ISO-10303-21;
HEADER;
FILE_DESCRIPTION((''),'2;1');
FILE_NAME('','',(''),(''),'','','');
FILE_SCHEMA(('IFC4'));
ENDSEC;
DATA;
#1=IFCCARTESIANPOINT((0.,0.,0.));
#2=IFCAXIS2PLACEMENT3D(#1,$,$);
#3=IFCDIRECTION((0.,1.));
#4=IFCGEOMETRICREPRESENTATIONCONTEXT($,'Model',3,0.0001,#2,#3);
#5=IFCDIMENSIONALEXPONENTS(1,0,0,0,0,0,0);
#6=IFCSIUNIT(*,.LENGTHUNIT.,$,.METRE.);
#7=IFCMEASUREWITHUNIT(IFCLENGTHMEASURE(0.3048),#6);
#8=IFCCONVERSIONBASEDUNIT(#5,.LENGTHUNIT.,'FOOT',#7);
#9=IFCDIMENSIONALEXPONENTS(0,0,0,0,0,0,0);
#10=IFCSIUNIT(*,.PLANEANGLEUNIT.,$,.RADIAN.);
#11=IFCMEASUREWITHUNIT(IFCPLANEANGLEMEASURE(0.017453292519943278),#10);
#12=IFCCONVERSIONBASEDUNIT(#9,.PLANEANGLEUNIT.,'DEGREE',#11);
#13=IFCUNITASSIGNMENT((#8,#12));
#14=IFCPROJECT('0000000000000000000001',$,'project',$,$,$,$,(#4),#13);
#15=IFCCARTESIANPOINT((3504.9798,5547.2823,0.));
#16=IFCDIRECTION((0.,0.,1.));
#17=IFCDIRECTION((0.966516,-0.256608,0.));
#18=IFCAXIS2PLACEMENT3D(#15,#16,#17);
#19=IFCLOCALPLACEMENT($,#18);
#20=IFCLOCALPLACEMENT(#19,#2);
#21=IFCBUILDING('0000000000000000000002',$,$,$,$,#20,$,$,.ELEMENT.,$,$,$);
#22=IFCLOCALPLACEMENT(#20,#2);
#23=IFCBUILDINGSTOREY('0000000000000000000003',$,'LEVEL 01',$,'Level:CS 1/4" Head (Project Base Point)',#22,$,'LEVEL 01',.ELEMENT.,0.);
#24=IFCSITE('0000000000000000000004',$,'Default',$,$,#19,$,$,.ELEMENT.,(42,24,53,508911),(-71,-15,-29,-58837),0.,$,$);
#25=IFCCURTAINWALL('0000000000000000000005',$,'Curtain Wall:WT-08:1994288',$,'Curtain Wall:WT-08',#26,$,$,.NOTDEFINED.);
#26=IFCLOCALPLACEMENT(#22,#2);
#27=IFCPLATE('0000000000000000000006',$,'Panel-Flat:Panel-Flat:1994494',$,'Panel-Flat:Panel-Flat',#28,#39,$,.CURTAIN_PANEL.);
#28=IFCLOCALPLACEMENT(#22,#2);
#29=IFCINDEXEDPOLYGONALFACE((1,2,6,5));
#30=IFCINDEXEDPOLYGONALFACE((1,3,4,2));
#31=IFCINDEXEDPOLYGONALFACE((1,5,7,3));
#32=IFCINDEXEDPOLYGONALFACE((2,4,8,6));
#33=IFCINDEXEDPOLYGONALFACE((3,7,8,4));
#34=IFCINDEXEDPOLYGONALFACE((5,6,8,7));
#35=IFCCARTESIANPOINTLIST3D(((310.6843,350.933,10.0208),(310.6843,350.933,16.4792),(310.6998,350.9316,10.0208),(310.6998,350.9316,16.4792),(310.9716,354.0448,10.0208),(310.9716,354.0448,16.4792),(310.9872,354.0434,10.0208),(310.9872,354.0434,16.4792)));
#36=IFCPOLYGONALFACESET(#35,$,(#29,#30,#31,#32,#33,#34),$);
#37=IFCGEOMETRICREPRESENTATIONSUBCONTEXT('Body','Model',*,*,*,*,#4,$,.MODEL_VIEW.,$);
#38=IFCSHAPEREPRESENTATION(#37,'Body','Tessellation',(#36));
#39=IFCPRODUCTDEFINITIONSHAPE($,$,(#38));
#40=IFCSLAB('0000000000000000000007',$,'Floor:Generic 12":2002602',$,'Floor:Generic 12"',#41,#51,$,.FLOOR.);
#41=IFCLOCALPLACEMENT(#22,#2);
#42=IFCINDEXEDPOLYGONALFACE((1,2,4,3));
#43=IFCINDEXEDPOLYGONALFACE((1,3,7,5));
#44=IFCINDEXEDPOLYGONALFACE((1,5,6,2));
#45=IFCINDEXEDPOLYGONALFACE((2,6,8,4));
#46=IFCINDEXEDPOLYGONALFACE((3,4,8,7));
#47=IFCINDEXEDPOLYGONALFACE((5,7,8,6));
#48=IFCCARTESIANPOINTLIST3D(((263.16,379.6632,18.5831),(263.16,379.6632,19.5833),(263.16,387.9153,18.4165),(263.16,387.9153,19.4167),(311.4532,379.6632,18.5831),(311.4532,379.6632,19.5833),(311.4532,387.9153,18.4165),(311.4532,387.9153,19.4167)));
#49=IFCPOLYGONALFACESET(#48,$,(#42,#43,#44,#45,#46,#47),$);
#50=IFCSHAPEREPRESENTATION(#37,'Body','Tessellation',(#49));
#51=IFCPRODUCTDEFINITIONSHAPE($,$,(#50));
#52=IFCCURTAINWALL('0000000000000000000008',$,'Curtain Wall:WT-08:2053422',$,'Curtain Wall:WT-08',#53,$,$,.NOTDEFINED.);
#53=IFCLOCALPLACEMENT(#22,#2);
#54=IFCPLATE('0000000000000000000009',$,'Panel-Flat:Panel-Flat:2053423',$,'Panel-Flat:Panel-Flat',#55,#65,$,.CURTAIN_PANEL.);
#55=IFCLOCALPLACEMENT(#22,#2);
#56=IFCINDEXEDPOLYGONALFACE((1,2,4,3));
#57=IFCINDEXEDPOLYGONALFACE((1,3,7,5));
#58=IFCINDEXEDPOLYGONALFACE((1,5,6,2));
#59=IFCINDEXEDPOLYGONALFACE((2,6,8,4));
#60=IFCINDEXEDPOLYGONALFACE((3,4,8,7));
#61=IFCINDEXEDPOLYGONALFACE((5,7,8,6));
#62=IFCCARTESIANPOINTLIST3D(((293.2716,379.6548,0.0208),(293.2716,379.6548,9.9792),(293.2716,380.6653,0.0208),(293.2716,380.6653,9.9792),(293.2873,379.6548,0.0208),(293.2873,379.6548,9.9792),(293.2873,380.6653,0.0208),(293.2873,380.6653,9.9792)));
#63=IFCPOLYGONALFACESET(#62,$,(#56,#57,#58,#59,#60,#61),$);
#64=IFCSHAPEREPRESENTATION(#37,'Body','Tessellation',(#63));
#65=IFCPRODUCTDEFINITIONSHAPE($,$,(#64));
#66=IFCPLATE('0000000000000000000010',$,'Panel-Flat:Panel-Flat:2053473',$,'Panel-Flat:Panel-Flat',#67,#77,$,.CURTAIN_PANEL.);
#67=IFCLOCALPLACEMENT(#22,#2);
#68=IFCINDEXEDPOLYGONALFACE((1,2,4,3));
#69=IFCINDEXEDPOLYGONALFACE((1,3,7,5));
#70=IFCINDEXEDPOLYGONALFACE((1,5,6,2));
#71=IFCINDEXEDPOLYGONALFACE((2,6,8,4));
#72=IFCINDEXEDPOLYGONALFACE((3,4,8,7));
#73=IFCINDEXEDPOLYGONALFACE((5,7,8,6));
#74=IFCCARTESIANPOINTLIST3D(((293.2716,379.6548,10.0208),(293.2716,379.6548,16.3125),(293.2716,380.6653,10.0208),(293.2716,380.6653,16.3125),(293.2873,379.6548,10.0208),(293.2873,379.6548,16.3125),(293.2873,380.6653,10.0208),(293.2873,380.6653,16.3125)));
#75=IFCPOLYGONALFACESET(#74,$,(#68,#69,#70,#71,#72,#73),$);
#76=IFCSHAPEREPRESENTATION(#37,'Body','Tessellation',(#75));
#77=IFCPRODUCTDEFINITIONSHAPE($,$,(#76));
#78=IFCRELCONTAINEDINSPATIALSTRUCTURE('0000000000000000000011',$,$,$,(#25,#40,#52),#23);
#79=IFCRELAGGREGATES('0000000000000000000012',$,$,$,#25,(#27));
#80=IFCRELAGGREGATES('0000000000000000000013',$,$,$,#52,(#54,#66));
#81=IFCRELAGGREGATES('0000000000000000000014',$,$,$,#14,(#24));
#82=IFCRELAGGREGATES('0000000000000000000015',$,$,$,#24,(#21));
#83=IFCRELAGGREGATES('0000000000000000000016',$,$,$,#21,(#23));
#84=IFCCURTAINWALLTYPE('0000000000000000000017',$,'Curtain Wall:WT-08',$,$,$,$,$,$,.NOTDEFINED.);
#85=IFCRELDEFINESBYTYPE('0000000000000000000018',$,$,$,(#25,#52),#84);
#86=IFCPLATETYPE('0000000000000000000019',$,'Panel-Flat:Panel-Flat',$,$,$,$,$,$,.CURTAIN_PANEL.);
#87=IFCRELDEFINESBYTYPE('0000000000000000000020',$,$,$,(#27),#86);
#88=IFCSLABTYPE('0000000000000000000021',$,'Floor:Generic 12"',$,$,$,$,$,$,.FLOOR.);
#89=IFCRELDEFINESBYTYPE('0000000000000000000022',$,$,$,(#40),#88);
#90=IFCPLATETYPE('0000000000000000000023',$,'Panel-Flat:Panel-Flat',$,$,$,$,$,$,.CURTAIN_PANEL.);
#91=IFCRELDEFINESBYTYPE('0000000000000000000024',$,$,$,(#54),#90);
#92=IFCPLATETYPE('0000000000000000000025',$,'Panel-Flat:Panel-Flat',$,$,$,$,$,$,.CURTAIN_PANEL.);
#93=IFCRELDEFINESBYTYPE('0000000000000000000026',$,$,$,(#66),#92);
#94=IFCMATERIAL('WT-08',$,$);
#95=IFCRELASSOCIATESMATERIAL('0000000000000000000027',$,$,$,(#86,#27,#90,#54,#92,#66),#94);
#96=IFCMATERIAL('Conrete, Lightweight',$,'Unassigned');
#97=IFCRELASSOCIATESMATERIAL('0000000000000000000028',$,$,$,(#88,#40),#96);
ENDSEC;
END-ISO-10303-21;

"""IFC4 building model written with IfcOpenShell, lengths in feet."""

from ifc_helpers import new_model, entity, si_unit, converted_unit, direction, frame, frame_2d, origin, place, context, subcontext, project, spatial, indexed_curve, rectangle, outline, extrude, source, transform, mapped, material, type_object, type_shapes, element, aggregate, save


model = new_model("IFC4")

# Units and contexts
model_context = context("Model", 3, precision=0.0001, world=origin(), true_north=direction((0.0, 1.0)))
body_context = subcontext(model_context, "Body", "Model", "MODEL_VIEW")
ifc_project = project(units=[converted_unit("LENGTHUNIT", "FOOT", entity("IfcLengthMeasure", 0.3048), si_unit("LENGTHUNIT", "METRE"), dimensions=[1, 0, 0, 0, 0, 0, 0]), converted_unit("PLANEANGLEUNIT", "DEGREE", entity("IfcPlaneAngleMeasure", 0.017453292519943278), si_unit("PLANEANGLEUNIT", "RADIAN"), dimensions=[0, 0, 0, 0, 0, 0, 0])], contexts=[model_context])

# Site, building, storey
site_placement = place(None, frame((3504.9798, 5547.2823, 0.0), z_axis=(0.0, 0.0, 1.0), x_axis=(0.966516, -0.256608, 0.0)))
site = spatial("IfcSite", under=ifc_project, at=site_placement, Name="Default", CompositionType="ELEMENT", RefLatitude=(42, 24, 53, 508911), RefLongitude=(-71, -15, -29, -58837), RefElevation=0.0)
building_placement = place(site_placement, origin())
building = spatial("IfcBuilding", under=site, at=building_placement, CompositionType="ELEMENT")
storey_placement = place(building_placement, origin())
storey = spatial("IfcBuildingStorey", under=building, at=storey_placement, Name="LEVEL 01", ObjectType="Level:CS 1/4\" Head (Project Base Point)", LongName="LEVEL 01", CompositionType="ELEMENT", Elevation=0.0)

# Curtain wall, plate
curtain_wall_type_1 = type_object("IfcCurtainWallType", Name="Curtain Wall:WT-08", PredefinedType="NOTDEFINED")
ifc_material_1 = material(Name="WT-08")
curtain_wall_1_placement = place(storey_placement, origin())
curtain_wall_1 = element("IfcCurtainWall", 1, at=curtain_wall_1_placement, inside=storey, type_object=curtain_wall_type_1, Name="Curtain Wall:WT-08:1994288", ObjectType="Curtain Wall:WT-08", PredefinedType="NOTDEFINED")
plate_type_1 = type_object("IfcPlateType", Name="Panel-Flat:Panel-Flat", PredefinedType="CURTAIN_PANEL", material=ifc_material_1)
shared_shape_1 = source(origin(), body_context, "Body", "SweptSolid", [
    extrude(outline(indexed_curve([(-0.0078, -1.5625), (0.0078, -1.5625), (0.0078, 1.5625), (-0.0078, 1.5625), (-0.0078, -1.5625)], self_intersect=False)), frame((1.5625, 0.0078, 0.0), z_axis=(0.0, 0.0, 1.0), x_axis=(0.0, -1.0, 0.0)), (0.0, 0.0, 1.0), 6.4583),
])
type_shapes(plate_type_1, [shared_shape_1])
plate_1_placement = place(curtain_wall_1_placement, frame((310.9716, 354.0448, 10.0208), z_axis=(0.0, 0.0, 1.0), x_axis=(-0.091962, -0.995763, 0.0)))
plate_1 = element("IfcPlate", 2, at=plate_1_placement, type_object=plate_type_1, material=ifc_material_1, Name="Panel-Flat:Panel-Flat:1994494", ObjectType="Panel-Flat:Panel-Flat", PredefinedType="CURTAIN_PANEL", context=body_context, shape_type="MappedRepresentation", body=[
    mapped(shared_shape_1, transform((0.0, 0.0, 0.0), scale=1.0)),
])
aggregate(curtain_wall_1, [plate_1])

# Slab
ifc_material_2 = material(Name="Conrete, Lightweight", Category="Unassigned")
slab_type = type_object("IfcSlabType", Name="Floor:Generic 12\"", PredefinedType="FLOOR", material=ifc_material_2)
slab_placement = place(storey_placement, frame((263.16, 379.6632, 18.4165)))
element("IfcSlab", 3, at=slab_placement, inside=storey, type_object=slab_type, material=ifc_material_2, Name="Floor:Generic 12\":2002602", ObjectType="Floor:Generic 12\"", PredefinedType="FLOOR", context=body_context, shape_type="SweptSolid", body=[
    extrude(rectangle(XDim=48.2932, YDim=8.2537, at=frame_2d((0.0, 4.1269), x_axis=(-1.0, 0.0))), frame((24.1466, 0.0, 1.1669), z_axis=(0.0, 0.020193, 0.999796), x_axis=(1.0, 0.0, 0.0)), (0.0, 0.020193, -0.999796), 1.0002),
])

# Curtain wall, plates
curtain_wall_2_placement = place(storey_placement, origin())
curtain_wall_2 = element("IfcCurtainWall", 4, at=curtain_wall_2_placement, inside=storey, type_object=curtain_wall_type_1, Name="Curtain Wall:WT-08:2053422", ObjectType="Curtain Wall:WT-08", PredefinedType="NOTDEFINED")
plate_type_2 = type_object("IfcPlateType", Name="Panel-Flat:Panel-Flat", PredefinedType="CURTAIN_PANEL", material=ifc_material_1)
shared_shape_2 = source(origin(), body_context, "Body", "SweptSolid", [
    extrude(outline(indexed_curve([(-0.0078, -0.5052), (0.0078, -0.5052), (0.0078, 0.5052), (-0.0078, 0.5052), (-0.0078, -0.5052)], self_intersect=False)), frame((0.5052, 0.0078, 0.0), z_axis=(0.0, 0.0, 1.0), x_axis=(0.0, -1.0, 0.0)), (0.0, 0.0, 1.0), 9.9583),
])
type_shapes(plate_type_2, [shared_shape_2])
plate_2_placement = place(curtain_wall_2_placement, frame((293.2716, 380.6653, 0.0208), z_axis=(0.0, 0.0, 1.0), x_axis=(0.0, -1.0, 0.0)))
plate_2 = element("IfcPlate", 5, at=plate_2_placement, type_object=plate_type_2, material=ifc_material_1, Name="Panel-Flat:Panel-Flat:2053423", ObjectType="Panel-Flat:Panel-Flat", PredefinedType="CURTAIN_PANEL", context=body_context, shape_type="MappedRepresentation", body=[
    mapped(shared_shape_2, transform((0.0, 0.0, 0.0), scale=1.0)),
])
plate_type_3 = type_object("IfcPlateType", Name="Panel-Flat:Panel-Flat", PredefinedType="CURTAIN_PANEL", material=ifc_material_1)
shared_shape_3 = source(origin(), body_context, "Body", "SweptSolid", [
    extrude(outline(indexed_curve([(-0.0078, -0.5052), (0.0078, -0.5052), (0.0078, 0.5052), (-0.0078, 0.5052), (-0.0078, -0.5052)], self_intersect=False)), frame((0.5052, 0.0078, 0.0), z_axis=(0.0, 0.0, 1.0), x_axis=(0.0, -1.0, 0.0)), (0.0, 0.0, 1.0), 6.2917),
])
type_shapes(plate_type_3, [shared_shape_3])
plate_3_placement = place(curtain_wall_2_placement, frame((293.2716, 380.6653, 10.0208), z_axis=(0.0, 0.0, 1.0), x_axis=(0.0, -1.0, 0.0)))
plate_3 = element("IfcPlate", 6, at=plate_3_placement, type_object=plate_type_3, material=ifc_material_1, Name="Panel-Flat:Panel-Flat:2053473", ObjectType="Panel-Flat:Panel-Flat", PredefinedType="CURTAIN_PANEL", context=body_context, shape_type="MappedRepresentation", body=[
    mapped(shared_shape_3, transform((0.0, 0.0, 0.0), scale=1.0)),
])
aggregate(curtain_wall_2, [plate_2, plate_3])

save(model, "model.ifc")
